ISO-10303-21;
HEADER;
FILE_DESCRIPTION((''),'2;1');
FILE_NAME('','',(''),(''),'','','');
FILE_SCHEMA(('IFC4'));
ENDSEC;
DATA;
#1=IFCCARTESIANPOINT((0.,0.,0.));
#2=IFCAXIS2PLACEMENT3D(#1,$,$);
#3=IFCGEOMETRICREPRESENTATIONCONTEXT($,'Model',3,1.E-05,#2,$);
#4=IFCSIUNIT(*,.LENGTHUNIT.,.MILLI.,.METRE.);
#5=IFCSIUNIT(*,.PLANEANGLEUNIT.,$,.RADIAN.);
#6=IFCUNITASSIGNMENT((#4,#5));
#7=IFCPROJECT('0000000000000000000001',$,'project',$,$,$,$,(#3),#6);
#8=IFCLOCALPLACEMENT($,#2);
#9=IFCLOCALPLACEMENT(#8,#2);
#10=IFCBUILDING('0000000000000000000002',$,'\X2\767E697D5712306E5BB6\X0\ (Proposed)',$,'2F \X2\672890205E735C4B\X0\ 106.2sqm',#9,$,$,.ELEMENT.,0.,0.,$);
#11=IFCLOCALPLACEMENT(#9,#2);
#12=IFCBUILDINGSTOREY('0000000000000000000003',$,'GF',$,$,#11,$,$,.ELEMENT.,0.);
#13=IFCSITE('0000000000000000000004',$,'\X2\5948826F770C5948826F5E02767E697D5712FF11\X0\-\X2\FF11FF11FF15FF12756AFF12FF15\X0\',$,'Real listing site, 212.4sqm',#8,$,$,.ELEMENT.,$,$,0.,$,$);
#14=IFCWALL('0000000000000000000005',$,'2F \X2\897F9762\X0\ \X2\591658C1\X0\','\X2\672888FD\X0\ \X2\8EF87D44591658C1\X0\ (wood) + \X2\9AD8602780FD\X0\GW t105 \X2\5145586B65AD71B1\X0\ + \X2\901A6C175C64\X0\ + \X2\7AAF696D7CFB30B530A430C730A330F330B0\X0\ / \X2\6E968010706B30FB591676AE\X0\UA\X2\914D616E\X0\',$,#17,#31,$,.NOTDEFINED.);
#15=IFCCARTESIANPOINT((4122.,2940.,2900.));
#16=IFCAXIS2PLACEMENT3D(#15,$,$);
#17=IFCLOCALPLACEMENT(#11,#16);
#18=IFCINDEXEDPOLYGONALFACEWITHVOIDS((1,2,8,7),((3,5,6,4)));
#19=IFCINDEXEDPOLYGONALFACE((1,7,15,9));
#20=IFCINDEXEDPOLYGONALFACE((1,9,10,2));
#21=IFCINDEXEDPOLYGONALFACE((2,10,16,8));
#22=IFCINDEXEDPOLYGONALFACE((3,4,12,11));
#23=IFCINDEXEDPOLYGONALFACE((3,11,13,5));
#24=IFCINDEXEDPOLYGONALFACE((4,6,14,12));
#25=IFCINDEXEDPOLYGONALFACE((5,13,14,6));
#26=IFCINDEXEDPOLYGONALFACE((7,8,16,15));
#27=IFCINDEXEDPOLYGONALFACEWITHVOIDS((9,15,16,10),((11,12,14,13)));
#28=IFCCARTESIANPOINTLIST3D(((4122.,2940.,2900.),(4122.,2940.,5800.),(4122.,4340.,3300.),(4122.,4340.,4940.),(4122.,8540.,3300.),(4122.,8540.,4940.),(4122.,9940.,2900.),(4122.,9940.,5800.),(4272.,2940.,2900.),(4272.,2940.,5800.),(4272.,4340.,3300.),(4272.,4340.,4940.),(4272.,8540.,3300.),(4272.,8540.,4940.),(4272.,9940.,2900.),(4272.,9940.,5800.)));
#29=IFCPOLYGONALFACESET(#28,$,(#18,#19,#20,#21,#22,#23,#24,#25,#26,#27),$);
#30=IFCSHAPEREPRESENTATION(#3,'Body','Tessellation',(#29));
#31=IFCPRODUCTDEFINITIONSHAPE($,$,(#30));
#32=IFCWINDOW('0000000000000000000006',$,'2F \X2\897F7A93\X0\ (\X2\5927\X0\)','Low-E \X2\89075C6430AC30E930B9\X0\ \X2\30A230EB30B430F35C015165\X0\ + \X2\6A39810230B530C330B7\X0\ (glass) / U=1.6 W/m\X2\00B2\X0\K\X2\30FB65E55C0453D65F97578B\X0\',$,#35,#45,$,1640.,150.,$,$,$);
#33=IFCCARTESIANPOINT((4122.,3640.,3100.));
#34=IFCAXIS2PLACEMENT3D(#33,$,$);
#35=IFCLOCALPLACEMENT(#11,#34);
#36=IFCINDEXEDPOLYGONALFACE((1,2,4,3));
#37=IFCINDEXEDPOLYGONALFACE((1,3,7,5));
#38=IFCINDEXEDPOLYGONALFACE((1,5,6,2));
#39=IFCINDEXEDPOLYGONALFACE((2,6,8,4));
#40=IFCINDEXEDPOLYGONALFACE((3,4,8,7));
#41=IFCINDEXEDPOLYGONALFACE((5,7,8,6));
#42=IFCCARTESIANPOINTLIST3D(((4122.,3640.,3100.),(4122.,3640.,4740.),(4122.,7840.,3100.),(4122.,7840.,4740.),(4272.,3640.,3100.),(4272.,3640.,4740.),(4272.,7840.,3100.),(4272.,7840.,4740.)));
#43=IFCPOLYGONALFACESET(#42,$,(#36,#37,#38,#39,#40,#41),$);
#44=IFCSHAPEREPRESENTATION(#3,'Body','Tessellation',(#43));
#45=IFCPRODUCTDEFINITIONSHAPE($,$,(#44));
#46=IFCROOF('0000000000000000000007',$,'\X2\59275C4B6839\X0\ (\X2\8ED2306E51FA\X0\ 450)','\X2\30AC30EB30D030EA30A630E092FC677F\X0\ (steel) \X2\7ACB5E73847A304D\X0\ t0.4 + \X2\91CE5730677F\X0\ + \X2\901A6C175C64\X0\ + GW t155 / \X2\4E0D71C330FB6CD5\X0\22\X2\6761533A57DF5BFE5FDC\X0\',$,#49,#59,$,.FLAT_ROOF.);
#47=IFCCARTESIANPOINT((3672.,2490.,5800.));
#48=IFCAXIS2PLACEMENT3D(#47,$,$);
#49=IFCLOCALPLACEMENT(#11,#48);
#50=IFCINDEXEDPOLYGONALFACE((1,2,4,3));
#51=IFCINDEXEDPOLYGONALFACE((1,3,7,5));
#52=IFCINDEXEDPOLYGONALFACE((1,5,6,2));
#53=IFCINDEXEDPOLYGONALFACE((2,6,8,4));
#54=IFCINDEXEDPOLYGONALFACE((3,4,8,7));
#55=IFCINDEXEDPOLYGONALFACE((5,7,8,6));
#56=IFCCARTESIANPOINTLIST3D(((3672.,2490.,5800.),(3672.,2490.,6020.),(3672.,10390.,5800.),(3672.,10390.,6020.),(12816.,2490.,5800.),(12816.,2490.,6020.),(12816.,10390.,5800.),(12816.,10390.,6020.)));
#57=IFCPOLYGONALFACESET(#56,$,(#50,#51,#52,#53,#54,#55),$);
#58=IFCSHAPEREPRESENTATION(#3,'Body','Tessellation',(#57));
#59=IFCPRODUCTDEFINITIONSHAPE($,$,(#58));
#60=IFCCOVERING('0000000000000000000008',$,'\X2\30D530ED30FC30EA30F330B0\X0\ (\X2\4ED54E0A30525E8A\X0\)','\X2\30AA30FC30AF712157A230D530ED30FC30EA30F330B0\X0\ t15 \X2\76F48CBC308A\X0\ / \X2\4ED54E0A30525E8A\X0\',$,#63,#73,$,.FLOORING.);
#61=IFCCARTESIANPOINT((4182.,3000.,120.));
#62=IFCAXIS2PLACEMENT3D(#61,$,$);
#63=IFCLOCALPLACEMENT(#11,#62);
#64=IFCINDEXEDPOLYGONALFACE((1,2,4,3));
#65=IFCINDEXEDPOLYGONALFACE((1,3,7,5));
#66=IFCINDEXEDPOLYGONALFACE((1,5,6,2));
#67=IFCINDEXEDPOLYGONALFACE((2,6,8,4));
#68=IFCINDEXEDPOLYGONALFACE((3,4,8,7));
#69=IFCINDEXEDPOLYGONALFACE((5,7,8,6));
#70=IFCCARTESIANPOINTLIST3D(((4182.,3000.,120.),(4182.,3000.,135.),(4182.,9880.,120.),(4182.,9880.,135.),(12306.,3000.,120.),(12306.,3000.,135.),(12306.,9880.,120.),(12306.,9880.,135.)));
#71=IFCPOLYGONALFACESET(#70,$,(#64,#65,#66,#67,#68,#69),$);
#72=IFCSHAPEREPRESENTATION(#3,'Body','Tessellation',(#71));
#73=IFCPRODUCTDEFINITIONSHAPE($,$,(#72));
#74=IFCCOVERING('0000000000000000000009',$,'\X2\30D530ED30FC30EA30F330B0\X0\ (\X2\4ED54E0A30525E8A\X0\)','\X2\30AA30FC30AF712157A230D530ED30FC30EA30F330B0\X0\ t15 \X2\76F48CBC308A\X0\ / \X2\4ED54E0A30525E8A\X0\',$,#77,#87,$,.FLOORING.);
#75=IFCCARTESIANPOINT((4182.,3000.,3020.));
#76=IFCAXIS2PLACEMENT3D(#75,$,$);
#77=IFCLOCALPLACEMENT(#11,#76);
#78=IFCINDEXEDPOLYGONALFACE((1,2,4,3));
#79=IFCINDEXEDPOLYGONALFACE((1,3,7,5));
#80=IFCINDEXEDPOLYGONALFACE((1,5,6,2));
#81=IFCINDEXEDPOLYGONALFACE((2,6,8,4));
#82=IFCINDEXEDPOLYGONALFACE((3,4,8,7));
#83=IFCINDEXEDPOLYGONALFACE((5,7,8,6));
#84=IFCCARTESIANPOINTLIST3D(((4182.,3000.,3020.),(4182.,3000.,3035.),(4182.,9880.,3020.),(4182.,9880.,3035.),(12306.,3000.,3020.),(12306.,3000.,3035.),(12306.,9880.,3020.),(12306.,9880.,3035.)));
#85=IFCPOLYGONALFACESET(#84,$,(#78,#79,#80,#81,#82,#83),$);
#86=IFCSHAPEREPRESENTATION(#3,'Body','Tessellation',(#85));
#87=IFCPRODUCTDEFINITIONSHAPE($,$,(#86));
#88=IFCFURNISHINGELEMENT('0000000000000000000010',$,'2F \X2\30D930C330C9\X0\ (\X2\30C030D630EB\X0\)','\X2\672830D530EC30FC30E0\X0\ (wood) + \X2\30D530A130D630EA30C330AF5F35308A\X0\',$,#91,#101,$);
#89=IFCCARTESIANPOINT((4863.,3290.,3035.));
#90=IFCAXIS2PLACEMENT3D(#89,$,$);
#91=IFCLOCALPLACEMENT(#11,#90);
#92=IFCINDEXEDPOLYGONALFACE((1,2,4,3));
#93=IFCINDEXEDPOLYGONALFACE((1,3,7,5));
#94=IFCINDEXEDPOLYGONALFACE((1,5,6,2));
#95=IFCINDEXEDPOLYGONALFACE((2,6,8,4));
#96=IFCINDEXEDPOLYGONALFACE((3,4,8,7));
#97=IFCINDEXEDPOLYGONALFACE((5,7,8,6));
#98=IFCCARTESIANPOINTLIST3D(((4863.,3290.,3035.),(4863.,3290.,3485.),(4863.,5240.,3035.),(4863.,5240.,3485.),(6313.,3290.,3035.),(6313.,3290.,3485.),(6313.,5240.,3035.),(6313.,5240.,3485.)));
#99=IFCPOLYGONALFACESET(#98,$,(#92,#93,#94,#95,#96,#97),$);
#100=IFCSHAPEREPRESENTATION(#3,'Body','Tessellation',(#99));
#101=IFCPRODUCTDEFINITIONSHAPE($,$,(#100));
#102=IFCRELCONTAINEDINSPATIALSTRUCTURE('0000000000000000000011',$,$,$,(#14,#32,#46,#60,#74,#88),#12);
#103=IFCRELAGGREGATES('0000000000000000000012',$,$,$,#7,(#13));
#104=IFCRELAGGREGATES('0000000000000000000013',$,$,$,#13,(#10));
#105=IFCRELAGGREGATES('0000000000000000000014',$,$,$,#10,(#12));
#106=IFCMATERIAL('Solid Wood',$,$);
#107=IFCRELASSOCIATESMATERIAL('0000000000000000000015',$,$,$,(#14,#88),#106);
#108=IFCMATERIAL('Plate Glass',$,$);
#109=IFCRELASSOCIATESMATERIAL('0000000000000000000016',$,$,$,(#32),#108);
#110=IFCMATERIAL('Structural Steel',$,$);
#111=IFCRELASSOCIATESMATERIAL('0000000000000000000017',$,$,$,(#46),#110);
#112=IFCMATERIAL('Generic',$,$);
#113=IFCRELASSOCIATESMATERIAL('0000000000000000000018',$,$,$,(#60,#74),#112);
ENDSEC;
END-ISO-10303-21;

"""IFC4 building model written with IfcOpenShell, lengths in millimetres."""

from ifc_helpers import new_model, si_unit, frame, frame_2d, origin, place, context, project, spatial, rectangle, extrude, material, element, fill, save


model = new_model("IFC4")

# Units and contexts
model_context = context("Model", 3, precision=1e-05, world=origin())
ifc_project = project(units=[si_unit("LENGTHUNIT", "METRE", prefix="MILLI"), si_unit("PLANEANGLEUNIT", "RADIAN")], contexts=[model_context])

# Site, building, storey
site_placement = place(None, origin())
site = spatial("IfcSite", under=ifc_project, at=site_placement, Name="奈良県奈良市百楽園１-１１５２番２５", ObjectType="Real listing site, 212.4sqm", CompositionType="ELEMENT", RefElevation=0.0)
building_placement = place(site_placement, origin())
building = spatial("IfcBuilding", under=site, at=building_placement, Name="百楽園の家 (Proposed)", ObjectType="2F 木造平屋 106.2sqm", CompositionType="ELEMENT", ElevationOfRefHeight=0.0, ElevationOfTerrain=0.0)
storey_placement = place(building_placement, origin())
storey = spatial("IfcBuildingStorey", under=building, at=storey_placement, Name="GF", CompositionType="ELEMENT", Elevation=0.0)

# Shared definitions
ifc_material_1 = material(Name="Solid Wood")

# Shared definitions
ifc_material_2 = material(Name="Plate Glass")

# Wall, opening, window
wall_1_placement = place(storey_placement, frame((4122.0, 2940.0, 2900.0)))
wall_1 = element("IfcWall", 1, at=wall_1_placement, inside=storey, material=ifc_material_1, Name="2F 西面 外壁", Description="木製 軸組外壁 (wood) + 高性能GW t105 充填断熱 + 通気層 + 窯業系サイディング / 準耐火・外皮UA配慮", PredefinedType="NOTDEFINED", context=model_context, shape_type="SweptSolid", body=[
    extrude(rectangle(XDim=150.0, YDim=7000.0, at=frame_2d((75.0, 3500.0))), frame((4122.0, 2940.0, 2900.0)), (0.0, 0.0, 1.0), 2900.0),
])
opening_1_placement = place(storey_placement, frame((4122.0, 3640.0, 3100.0)))
opening_1 = element("IfcOpeningElement", 2, at=opening_1_placement, cuts=wall_1, PredefinedType="NOTDEFINED", context=model_context, shape_type="SweptSolid", body=[
    extrude(rectangle(XDim=150.0, YDim=4200.0, at=frame_2d((75.0, 2100.0))), frame((4122.0, 3640.0, 3100.0)), (0.0, 0.0, 1.0), 1640.0),
])
window_1_placement = place(storey_placement, frame((4122.0, 3640.0, 3100.0)))
window_1 = element("IfcWindow", 3, at=window_1_placement, inside=storey, material=ifc_material_2, Name="2F 西窓 (大)", Description="Low-E 複層ガラス アルゴン封入 + 樹脂サッシ (glass) / U=1.6 W/m²K・日射取得型", OverallHeight=1640.0, OverallWidth=150.0, context=model_context, shape_type="SweptSolid", body=[
    extrude(rectangle(XDim=150.0, YDim=4200.0, at=frame_2d((75.0, 2100.0))), frame((4122.0, 3640.0, 3100.0)), (0.0, 0.0, 1.0), 1640.0),
])
fill(opening_1, window_1)

# Roof
ifc_material_3 = material(Name="Structural Steel")
roof_placement = place(storey_placement, frame((3672.0, 2490.0, 5800.0)))
element("IfcRoof", 4, at=roof_placement, inside=storey, material=ifc_material_3, Name="大屋根 (軒の出 450)", Description="ガルバリウム鋼板 (steel) 立平葺き t0.4 + 野地板 + 通気層 + GW t155 / 不燃・法22条区域対応", PredefinedType="FLAT_ROOF", context=model_context, shape_type="SweptSolid", body=[
    extrude(rectangle(XDim=9144.0, YDim=7900.0, at=frame_2d((4572.0, 3950.0))), frame((3672.0, 2490.0, 5800.0)), (0.0, 0.0, 1.0), 220.0),
])

# Coverings
ifc_material_4 = material(Name="Generic")
covering_1_placement = place(storey_placement, frame((4182.0, 3000.0, 120.0)))
element("IfcCovering", 5, at=covering_1_placement, inside=storey, material=ifc_material_4, Name="フローリング (仕上げ床)", Description="オーク無垢フローリング t15 直貼り / 仕上げ床", PredefinedType="FLOORING", context=model_context, shape_type="SweptSolid", body=[
    extrude(rectangle(XDim=8124.0, YDim=6880.0, at=frame_2d((4062.0, 3440.0))), frame((4182.0, 3000.0, 120.0)), (0.0, 0.0, 1.0), 15.0),
])
covering_2_placement = place(storey_placement, frame((4182.0, 3000.0, 3020.0)))
element("IfcCovering", 6, at=covering_2_placement, inside=storey, material=ifc_material_4, Name="フローリング (仕上げ床)", Description="オーク無垢フローリング t15 直貼り / 仕上げ床", PredefinedType="FLOORING", context=model_context, shape_type="SweptSolid", body=[
    extrude(rectangle(XDim=8124.0, YDim=6880.0, at=frame_2d((4062.0, 3440.0))), frame((4182.0, 3000.0, 3020.0)), (0.0, 0.0, 1.0), 15.0),
])

# Furnishing element
furnishing_placement = place(storey_placement, frame((4863.0, 3290.0, 3035.0)))
element("IfcFurnishingElement", 7, at=furnishing_placement, inside=storey, material=ifc_material_1, Name="2F ベッド (ダブル)", Description="木フレーム (wood) + ファブリック張り", context=model_context, shape_type="SweptSolid", body=[
    extrude(rectangle(XDim=1450.0, YDim=1950.0, at=frame_2d((725.0, 975.0))), frame((4863.0, 3290.0, 3035.0)), (0.0, 0.0, 1.0), 450.0),
])

save(model, "model.ifc")
